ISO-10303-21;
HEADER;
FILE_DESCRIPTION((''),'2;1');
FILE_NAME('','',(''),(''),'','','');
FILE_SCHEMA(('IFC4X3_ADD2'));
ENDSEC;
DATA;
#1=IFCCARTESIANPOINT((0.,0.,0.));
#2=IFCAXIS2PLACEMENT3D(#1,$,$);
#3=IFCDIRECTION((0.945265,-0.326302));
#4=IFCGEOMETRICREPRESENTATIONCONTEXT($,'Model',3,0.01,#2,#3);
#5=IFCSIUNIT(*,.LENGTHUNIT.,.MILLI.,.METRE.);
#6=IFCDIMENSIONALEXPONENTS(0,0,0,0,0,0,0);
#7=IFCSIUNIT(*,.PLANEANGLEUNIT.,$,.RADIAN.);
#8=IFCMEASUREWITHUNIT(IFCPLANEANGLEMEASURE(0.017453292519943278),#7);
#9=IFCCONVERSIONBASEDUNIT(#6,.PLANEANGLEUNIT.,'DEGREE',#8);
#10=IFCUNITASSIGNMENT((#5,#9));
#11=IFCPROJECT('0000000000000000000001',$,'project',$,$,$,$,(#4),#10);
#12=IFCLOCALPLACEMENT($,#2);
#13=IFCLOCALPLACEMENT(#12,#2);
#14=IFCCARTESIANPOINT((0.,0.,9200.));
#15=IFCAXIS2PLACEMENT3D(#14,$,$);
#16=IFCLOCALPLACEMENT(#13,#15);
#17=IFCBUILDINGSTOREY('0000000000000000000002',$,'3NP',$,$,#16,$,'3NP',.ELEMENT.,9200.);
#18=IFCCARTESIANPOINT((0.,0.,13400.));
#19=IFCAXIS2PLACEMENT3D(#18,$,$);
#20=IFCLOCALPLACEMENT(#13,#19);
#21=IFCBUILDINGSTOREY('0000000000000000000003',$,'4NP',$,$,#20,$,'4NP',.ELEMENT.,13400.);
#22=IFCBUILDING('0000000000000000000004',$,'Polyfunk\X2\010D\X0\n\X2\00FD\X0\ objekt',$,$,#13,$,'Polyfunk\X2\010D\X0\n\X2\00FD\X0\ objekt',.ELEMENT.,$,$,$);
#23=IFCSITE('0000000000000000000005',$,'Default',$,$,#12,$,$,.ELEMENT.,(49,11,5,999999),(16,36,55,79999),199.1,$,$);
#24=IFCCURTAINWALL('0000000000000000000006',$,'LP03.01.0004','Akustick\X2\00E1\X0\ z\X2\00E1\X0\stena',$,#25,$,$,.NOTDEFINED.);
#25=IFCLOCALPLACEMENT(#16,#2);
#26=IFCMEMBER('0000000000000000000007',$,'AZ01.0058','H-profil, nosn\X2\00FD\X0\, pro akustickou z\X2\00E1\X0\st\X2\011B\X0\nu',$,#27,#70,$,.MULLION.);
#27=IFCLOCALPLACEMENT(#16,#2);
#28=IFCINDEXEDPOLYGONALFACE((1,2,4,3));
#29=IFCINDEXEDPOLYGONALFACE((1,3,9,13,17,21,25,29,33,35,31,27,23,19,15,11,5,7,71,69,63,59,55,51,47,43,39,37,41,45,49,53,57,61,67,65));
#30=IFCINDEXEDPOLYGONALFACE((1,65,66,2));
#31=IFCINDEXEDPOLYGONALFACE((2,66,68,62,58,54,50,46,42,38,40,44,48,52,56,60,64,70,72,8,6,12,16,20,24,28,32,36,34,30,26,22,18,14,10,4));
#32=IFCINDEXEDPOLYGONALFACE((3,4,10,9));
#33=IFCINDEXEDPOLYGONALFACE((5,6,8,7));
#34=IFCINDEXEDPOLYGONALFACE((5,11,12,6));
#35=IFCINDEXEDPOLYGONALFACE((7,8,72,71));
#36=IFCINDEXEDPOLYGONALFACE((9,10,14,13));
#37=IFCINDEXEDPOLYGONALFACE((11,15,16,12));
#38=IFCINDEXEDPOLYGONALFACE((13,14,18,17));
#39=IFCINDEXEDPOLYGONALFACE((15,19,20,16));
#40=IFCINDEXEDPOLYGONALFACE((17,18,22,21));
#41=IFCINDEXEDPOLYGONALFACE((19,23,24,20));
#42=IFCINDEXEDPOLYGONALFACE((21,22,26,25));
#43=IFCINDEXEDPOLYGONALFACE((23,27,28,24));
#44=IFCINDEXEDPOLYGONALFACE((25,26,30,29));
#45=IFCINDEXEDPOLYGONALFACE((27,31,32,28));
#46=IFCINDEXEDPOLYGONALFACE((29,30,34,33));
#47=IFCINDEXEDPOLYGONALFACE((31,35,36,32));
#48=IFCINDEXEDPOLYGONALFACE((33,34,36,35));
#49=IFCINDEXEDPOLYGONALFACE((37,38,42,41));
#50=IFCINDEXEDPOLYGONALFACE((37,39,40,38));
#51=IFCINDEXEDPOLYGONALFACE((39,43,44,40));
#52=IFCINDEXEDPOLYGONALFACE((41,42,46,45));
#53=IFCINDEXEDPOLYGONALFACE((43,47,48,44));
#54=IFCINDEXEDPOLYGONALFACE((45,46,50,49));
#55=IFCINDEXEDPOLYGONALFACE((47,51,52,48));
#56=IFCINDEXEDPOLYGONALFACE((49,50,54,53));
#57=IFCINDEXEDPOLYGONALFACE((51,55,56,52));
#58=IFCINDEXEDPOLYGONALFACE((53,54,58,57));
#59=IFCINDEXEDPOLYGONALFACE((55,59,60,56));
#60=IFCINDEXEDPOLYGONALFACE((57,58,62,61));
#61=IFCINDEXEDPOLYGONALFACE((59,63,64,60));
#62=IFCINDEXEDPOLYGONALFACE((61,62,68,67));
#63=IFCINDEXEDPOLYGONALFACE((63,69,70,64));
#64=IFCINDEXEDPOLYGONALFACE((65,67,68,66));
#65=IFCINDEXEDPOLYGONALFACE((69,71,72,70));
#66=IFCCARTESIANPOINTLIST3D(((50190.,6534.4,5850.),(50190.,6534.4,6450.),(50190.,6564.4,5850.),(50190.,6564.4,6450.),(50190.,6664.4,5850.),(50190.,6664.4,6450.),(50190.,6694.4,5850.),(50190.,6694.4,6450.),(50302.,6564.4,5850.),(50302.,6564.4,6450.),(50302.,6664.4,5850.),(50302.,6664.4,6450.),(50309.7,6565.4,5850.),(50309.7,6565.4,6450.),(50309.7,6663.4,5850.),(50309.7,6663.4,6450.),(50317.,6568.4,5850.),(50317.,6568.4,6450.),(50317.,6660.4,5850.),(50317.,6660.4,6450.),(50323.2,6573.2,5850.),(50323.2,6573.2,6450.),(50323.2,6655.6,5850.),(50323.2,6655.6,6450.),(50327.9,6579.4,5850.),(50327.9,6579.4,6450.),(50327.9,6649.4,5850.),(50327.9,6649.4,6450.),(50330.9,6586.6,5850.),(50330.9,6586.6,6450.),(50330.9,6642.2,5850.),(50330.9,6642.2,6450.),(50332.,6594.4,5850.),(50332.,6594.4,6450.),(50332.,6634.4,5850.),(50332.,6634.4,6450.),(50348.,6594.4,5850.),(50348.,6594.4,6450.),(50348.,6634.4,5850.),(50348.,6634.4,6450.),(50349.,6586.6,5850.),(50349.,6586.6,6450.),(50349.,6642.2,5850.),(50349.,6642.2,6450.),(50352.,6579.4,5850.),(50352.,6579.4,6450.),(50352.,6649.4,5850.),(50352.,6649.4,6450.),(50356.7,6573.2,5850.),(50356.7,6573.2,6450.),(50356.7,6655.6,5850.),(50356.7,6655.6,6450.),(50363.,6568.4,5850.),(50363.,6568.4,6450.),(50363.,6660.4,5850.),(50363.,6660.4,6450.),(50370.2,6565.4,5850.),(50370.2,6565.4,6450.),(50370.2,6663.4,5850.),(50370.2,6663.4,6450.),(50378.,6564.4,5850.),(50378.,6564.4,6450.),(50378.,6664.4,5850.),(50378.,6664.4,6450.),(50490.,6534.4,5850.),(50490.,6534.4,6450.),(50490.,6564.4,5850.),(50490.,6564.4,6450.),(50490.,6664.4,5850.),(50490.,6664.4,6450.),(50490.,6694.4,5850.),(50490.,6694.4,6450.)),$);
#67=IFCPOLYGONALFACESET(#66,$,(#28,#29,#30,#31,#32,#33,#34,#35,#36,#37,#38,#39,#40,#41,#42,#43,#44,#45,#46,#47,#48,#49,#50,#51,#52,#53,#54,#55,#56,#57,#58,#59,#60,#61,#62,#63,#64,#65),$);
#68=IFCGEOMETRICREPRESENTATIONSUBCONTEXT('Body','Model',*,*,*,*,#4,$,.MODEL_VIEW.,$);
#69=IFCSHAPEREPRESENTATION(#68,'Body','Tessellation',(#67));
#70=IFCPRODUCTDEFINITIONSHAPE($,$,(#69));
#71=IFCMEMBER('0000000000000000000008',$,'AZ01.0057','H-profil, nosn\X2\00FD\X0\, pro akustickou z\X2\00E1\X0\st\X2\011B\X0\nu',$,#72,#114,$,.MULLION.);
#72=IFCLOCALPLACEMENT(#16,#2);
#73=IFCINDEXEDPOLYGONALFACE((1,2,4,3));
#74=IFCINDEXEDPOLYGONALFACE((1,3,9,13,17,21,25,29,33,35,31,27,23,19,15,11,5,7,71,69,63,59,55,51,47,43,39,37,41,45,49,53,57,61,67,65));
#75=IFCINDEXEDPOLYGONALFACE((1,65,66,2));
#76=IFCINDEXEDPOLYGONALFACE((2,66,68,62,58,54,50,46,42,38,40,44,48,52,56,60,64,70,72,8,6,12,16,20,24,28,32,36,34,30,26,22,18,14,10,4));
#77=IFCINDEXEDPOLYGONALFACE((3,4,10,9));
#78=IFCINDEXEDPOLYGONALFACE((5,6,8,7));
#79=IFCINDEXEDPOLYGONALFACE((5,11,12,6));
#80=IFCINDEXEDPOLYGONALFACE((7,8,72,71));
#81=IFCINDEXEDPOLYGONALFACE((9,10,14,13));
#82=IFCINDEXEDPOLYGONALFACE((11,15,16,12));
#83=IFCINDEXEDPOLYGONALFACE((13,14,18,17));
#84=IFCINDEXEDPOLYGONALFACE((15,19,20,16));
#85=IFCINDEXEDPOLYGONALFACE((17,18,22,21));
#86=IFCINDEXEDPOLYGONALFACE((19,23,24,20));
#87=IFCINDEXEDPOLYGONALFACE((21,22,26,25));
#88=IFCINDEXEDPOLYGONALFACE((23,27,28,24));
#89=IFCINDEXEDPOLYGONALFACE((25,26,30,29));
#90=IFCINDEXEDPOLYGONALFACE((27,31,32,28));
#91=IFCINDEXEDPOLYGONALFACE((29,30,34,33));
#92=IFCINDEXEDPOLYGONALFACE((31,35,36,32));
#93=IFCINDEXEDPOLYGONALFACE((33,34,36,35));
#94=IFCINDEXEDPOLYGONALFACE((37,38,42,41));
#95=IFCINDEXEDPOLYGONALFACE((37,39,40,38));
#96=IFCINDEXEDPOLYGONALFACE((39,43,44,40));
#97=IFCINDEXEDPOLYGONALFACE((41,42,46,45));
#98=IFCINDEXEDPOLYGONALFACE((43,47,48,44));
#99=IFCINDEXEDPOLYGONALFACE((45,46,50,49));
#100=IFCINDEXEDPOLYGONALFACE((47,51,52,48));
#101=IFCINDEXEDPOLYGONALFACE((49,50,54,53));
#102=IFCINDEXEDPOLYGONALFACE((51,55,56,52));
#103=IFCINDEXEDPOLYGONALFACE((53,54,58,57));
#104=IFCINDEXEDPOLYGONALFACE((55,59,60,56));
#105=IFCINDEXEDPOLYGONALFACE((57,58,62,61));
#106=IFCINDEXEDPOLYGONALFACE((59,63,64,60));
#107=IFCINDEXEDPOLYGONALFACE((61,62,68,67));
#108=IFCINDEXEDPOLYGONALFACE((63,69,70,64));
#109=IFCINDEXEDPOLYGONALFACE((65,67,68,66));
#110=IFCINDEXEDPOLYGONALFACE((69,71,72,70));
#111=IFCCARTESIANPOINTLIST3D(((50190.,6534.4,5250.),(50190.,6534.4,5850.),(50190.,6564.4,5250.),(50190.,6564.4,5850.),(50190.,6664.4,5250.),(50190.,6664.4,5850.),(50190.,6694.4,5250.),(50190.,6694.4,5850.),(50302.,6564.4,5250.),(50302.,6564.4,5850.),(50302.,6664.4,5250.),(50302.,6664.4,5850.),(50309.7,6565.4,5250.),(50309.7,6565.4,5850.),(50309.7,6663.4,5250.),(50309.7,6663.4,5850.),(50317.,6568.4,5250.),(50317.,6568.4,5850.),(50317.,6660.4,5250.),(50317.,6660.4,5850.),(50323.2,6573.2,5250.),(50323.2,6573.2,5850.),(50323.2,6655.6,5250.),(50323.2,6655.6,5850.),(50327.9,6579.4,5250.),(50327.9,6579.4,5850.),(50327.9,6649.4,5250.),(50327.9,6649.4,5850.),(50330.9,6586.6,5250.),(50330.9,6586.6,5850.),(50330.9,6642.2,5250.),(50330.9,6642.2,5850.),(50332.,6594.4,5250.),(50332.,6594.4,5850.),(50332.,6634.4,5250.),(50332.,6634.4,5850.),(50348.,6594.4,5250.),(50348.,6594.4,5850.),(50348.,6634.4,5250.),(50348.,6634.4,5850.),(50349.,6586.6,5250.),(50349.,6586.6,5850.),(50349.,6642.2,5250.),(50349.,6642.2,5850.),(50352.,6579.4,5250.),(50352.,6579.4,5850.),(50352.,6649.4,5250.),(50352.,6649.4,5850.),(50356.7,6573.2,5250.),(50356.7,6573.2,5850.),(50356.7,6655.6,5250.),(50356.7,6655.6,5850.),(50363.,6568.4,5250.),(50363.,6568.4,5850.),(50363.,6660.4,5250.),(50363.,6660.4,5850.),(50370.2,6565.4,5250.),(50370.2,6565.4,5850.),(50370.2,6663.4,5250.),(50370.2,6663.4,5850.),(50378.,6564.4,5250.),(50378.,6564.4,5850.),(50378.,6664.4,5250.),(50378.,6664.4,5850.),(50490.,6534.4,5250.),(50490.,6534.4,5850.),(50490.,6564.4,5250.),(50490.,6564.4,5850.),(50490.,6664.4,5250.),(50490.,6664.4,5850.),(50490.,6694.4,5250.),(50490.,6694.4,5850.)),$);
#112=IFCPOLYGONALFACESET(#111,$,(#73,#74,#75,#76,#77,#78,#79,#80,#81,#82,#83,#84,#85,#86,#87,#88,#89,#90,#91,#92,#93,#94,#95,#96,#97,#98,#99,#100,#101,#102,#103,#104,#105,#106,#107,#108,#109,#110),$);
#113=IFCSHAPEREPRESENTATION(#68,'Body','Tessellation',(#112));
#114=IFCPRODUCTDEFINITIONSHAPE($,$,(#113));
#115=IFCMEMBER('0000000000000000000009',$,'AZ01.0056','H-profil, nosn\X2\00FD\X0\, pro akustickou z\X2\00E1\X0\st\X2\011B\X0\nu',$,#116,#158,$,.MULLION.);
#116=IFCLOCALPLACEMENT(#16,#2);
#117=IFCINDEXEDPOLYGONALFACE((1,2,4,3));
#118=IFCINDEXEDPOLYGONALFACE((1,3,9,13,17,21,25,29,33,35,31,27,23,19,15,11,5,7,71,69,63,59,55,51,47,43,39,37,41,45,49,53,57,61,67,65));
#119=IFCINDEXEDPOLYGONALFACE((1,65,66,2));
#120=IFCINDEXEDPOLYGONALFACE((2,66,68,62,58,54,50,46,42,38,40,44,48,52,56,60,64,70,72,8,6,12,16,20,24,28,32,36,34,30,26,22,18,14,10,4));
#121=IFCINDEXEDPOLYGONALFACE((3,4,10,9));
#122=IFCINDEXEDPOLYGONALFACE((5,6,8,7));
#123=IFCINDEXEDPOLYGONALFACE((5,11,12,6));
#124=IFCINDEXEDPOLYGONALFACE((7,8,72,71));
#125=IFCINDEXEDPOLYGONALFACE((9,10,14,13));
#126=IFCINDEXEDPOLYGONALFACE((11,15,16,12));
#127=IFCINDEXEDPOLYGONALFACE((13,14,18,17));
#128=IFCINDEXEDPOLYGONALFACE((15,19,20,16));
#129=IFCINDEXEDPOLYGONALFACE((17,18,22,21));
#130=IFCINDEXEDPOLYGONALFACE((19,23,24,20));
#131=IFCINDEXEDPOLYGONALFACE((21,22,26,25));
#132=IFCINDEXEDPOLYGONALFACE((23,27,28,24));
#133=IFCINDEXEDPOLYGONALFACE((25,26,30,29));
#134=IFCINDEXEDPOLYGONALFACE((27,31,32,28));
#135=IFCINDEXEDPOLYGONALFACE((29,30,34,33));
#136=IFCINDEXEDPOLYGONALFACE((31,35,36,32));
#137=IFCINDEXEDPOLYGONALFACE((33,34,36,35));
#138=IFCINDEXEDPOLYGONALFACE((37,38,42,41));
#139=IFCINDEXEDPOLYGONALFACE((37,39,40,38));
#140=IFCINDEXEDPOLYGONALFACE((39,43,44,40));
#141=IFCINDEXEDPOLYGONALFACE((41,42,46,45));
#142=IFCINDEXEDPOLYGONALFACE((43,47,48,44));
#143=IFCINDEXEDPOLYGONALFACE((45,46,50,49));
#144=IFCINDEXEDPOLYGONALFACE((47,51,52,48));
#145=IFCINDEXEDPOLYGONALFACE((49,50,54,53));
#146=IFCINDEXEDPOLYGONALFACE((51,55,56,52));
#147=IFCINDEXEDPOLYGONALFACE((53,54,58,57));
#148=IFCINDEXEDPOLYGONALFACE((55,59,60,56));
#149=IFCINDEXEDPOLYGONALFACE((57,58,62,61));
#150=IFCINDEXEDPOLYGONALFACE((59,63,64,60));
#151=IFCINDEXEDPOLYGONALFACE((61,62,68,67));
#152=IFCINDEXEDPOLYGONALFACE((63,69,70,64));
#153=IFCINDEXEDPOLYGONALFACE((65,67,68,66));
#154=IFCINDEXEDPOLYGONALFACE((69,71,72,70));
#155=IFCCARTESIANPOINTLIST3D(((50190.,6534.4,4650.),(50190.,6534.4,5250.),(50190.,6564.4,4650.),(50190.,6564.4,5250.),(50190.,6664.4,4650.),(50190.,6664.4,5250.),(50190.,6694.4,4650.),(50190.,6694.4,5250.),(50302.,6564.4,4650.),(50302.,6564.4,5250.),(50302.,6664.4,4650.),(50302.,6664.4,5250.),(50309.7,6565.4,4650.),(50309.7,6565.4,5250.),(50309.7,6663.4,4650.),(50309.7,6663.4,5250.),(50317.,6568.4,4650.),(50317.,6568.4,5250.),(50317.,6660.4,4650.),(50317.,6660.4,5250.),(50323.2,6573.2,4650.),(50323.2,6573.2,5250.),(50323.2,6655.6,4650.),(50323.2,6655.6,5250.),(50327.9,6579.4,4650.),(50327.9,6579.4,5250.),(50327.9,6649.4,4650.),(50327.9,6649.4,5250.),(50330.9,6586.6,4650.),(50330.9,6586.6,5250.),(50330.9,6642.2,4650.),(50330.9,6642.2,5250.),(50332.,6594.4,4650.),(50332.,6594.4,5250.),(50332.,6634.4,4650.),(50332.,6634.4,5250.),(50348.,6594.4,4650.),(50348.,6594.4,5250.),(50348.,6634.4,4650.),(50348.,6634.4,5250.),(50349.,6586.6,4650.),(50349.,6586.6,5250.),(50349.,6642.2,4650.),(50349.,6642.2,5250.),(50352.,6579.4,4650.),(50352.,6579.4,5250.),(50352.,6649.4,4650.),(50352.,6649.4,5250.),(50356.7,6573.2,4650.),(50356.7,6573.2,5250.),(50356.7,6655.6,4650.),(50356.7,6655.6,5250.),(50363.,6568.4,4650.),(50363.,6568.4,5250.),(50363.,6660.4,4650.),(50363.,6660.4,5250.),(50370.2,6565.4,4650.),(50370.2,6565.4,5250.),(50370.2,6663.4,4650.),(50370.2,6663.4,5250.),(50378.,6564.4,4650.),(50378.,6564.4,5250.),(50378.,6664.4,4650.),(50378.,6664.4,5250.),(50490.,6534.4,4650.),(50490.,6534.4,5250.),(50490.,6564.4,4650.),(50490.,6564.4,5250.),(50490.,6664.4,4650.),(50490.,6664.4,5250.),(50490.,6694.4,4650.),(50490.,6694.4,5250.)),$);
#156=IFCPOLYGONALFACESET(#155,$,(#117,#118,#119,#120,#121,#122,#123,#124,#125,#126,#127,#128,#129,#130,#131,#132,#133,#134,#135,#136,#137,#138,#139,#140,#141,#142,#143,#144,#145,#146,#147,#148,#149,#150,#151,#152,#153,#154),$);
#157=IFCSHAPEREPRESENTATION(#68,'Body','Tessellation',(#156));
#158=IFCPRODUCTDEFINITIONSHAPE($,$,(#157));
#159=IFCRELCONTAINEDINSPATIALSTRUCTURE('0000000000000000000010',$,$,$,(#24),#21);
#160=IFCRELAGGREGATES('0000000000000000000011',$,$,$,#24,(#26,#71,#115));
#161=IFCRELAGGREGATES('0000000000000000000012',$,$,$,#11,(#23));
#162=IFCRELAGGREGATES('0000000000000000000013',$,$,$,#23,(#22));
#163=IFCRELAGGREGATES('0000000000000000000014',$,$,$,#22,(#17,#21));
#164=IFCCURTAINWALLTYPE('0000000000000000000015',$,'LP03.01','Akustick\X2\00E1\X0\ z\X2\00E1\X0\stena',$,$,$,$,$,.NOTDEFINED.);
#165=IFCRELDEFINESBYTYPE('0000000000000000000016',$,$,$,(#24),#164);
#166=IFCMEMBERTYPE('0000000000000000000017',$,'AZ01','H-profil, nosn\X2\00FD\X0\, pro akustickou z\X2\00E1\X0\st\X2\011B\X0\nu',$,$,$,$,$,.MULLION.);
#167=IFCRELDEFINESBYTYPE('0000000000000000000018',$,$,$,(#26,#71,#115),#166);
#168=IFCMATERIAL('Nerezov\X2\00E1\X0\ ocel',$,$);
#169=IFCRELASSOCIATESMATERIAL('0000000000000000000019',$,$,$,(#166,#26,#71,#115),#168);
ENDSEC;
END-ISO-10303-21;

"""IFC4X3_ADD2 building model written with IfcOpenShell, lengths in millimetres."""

from ifc_helpers import new_model, entity, si_unit, converted_unit, direction, frame, frame_2d, origin, place, context, subcontext, project, spatial, polyline, circle_curve, parameter, trimmed, segment, composite_curve, outline, extrude, source, transform, mapped, material, material_profile, profile_set, profile_usage, type_object, element, aggregate, save


model = new_model("IFC4X3_ADD2")

# Units and contexts
model_context = context("Model", 3, precision=0.01, world=origin(), true_north=direction((0.945265, -0.326302)))
body_context = subcontext(model_context, "Body", "Model", "MODEL_VIEW")
ifc_project = project(units=[si_unit("LENGTHUNIT", "METRE", prefix="MILLI"), converted_unit("PLANEANGLEUNIT", "DEGREE", entity("IfcPlaneAngleMeasure", 0.017453292519943278), si_unit("PLANEANGLEUNIT", "RADIAN"), dimensions=[0, 0, 0, 0, 0, 0, 0])], contexts=[model_context])

# Site, building, storey
site_placement = place(None, origin())
site = spatial("IfcSite", under=ifc_project, at=site_placement, Name="Default", CompositionType="ELEMENT", RefLatitude=(49, 11, 5, 999999), RefLongitude=(16, 36, 55, 79999), RefElevation=199.1)
building_placement = place(site_placement, origin())
building = spatial("IfcBuilding", under=site, at=building_placement, Name="Polyfunkčný objekt", LongName="Polyfunkčný objekt", CompositionType="ELEMENT")
storey_1_placement = place(building_placement, frame((0.0, 0.0, 9200.0)))
storey_1 = spatial("IfcBuildingStorey", under=building, at=storey_1_placement, Name="3NP", LongName="3NP", CompositionType="ELEMENT", Elevation=9200.0)

# Shared definitions
storey_2_placement = place(building_placement, frame((0.0, 0.0, 13400.0)))
storey_2 = spatial("IfcBuildingStorey", under=building, at=storey_2_placement, Name="4NP", LongName="4NP", CompositionType="ELEMENT", Elevation=13400.0)

# Curtain wall, members
curtain_wall_type_1 = type_object("IfcCurtainWallType", Name="LP03.01", Description="Akustická zástena", PredefinedType="NOTDEFINED")
curtain_wall_1_placement = place(storey_2_placement, frame((0.0, 0.0, -13400.0)))
curtain_wall_1 = element("IfcCurtainWall", 1, at=curtain_wall_1_placement, inside=storey_2, type_object=curtain_wall_type_1, Name="LP03.01.0004", Description="Akustická zástena", PredefinedType="NOTDEFINED")
ifc_material_1 = material(Name="Nerezová ocel")
ifc_material_profile_1 = material_profile(ifc_material_1, outline(composite_curve([segment(polyline([(50.0, -150.0), (80.0, -150.0)]), True, "CONTINUOUS"), segment(polyline([(80.0, -150.0), (80.0, 150.0)]), True, "CONTINUOUS"), segment(polyline([(80.0, 150.0), (50.0, 150.0)]), True, "CONTINUOUS"), segment(polyline([(50.0, 150.0), (50.0, 38.0)]), True, "CONTINUOUS"), segment(trimmed(circle_curve(frame_2d((20.0, 38.0), x_axis=(0.0, 1.0)), 30.0), [parameter(180.0)], [parameter(270.0)], True, "PARAMETER"), False, "CONTINUOUS"), segment(polyline([(20.0, 8.0), (-20.0, 8.0)]), True, "CONTINUOUS"), segment(trimmed(circle_curve(frame_2d((-20.0, 38.0), x_axis=(0.0, 1.0)), 30.0), [parameter(90.0)], [parameter(180.0)], True, "PARAMETER"), False, "CONTINUOUS"), segment(polyline([(-50.0, 38.0), (-50.0, 150.0)]), True, "CONTINUOUS"), segment(polyline([(-50.0, 150.0), (-80.0, 150.0)]), True, "CONTINUOUS"), segment(polyline([(-80.0, 150.0), (-80.0, -150.0)]), True, "CONTINUOUS"), segment(polyline([(-80.0, -150.0), (-50.0, -150.0)]), True, "CONTINUOUS"), segment(polyline([(-50.0, -150.0), (-50.0, -38.0)]), True, "CONTINUOUS"), segment(trimmed(circle_curve(frame_2d((-20.0, -38.0), x_axis=(0.0, 1.0)), 30.0), [parameter(0.0)], [parameter(90.0)], True, "PARAMETER"), False, "CONTINUOUS"), segment(polyline([(-20.0, -8.0), (20.0, -8.0)]), True, "CONTINUOUS"), segment(trimmed(circle_curve(frame_2d((20.0, -38.0), x_axis=(0.0, 1.0)), 30.0), [parameter(270.0)], [parameter(0.0)], True, "PARAMETER"), False, "CONTINUOUS"), segment(polyline([(50.0, -38.0), (50.0, -150.0)]), True, "CONTINUOUS")], self_intersect=False)), Name="Profil zástena")
ifc_profile_set_1 = profile_set([ifc_material_profile_1], Name="Profil zástena")
ifc_profile_usage_1 = profile_usage(ifc_profile_set_1)
member_type_1 = type_object("IfcMemberType", Name="AZ01", Description="H-profil, nosný, pro akustickou zástěnu", PredefinedType="MULLION", material=ifc_profile_set_1)
shared_shape_1 = source(origin(), body_context, "Body", "SweptSolid", [
    extrude(outline(composite_curve([segment(polyline([(-150.0, -50.0), (-150.0, -80.0)]), True, "CONTINUOUS"), segment(polyline([(-150.0, -80.0), (150.0, -80.0)]), True, "CONTINUOUS"), segment(polyline([(150.0, -80.0), (150.0, -50.0)]), True, "CONTINUOUS"), segment(polyline([(150.0, -50.0), (38.0, -50.0)]), True, "CONTINUOUS"), segment(trimmed(circle_curve(frame_2d((38.0, -20.0), x_axis=(1.0, 0.0)), 30.0), [parameter(180.0)], [parameter(270.0)], True, "PARAMETER"), False, "CONTINUOUS"), segment(polyline([(8.0, -20.0), (8.0, 20.0)]), True, "CONTINUOUS"), segment(trimmed(circle_curve(frame_2d((38.0, 20.0), x_axis=(1.0, 0.0)), 30.0), [parameter(90.0)], [parameter(180.0)], True, "PARAMETER"), False, "CONTINUOUS"), segment(polyline([(38.0, 50.0), (150.0, 50.0)]), True, "CONTINUOUS"), segment(polyline([(150.0, 50.0), (150.0, 80.0)]), True, "CONTINUOUS"), segment(polyline([(150.0, 80.0), (-150.0, 80.0)]), True, "CONTINUOUS"), segment(polyline([(-150.0, 80.0), (-150.0, 50.0)]), True, "CONTINUOUS"), segment(polyline([(-150.0, 50.0), (-38.0, 50.0)]), True, "CONTINUOUS"), segment(trimmed(circle_curve(frame_2d((-38.0, 20.0), x_axis=(1.0, 0.0)), 30.0), [parameter(0.0)], [parameter(90.0)], True, "PARAMETER"), False, "CONTINUOUS"), segment(polyline([(-8.0, 20.0), (-8.0, -20.0)]), True, "CONTINUOUS"), segment(trimmed(circle_curve(frame_2d((-38.0, -20.0), x_axis=(1.0, 0.0)), 30.0), [parameter(270.0)], [parameter(0.0)], True, "PARAMETER"), False, "CONTINUOUS"), segment(polyline([(-38.0, -50.0), (-150.0, -50.0)]), True, "CONTINUOUS")], self_intersect=False)), frame((-150.0, 0.0, -600.0), z_axis=(0.0, 0.0, -1.0), x_axis=(-1.0, 0.0, 0.0)), (0.0, 0.0, -1.0), 600.0),
])
member_1_placement = place(curtain_wall_1_placement, frame((50190.0, 6614.4, 15650.0), z_axis=(0.0, 0.0, 1.0), x_axis=(-1.0, 0.0, 0.0)))
member_1 = element("IfcMember", 2, at=member_1_placement, type_object=member_type_1, material=ifc_profile_usage_1, Name="AZ01.0058", Description="H-profil, nosný, pro akustickou zástěnu", PredefinedType="MULLION", context=body_context, shape_type="MappedRepresentation", body=[
    mapped(shared_shape_1, transform((0.0, 0.0, 0.0), scale=1.0)),
])
member_2_placement = place(curtain_wall_1_placement, frame((50190.0, 6614.4, 15050.0), z_axis=(0.0, 0.0, 1.0), x_axis=(-1.0, 0.0, 0.0)))
member_2 = element("IfcMember", 3, at=member_2_placement, type_object=member_type_1, material=ifc_profile_usage_1, Name="AZ01.0057", Description="H-profil, nosný, pro akustickou zástěnu", PredefinedType="MULLION", context=body_context, shape_type="MappedRepresentation", body=[
    mapped(shared_shape_1, transform((0.0, 0.0, 0.0), scale=1.0)),
])
member_3_placement = place(curtain_wall_1_placement, frame((50190.0, 6614.4, 14450.0), z_axis=(0.0, 0.0, 1.0), x_axis=(-1.0, 0.0, 0.0)))
member_3 = element("IfcMember", 4, at=member_3_placement, type_object=member_type_1, material=ifc_profile_usage_1, Name="AZ01.0056", Description="H-profil, nosný, pro akustickou zástěnu", PredefinedType="MULLION", context=body_context, shape_type="MappedRepresentation", body=[
    mapped(shared_shape_1, transform((0.0, 0.0, 0.0), scale=1.0)),
])

aggregate(curtain_wall_1, [member_1, member_2, member_3])

save(model, "model.ifc")
